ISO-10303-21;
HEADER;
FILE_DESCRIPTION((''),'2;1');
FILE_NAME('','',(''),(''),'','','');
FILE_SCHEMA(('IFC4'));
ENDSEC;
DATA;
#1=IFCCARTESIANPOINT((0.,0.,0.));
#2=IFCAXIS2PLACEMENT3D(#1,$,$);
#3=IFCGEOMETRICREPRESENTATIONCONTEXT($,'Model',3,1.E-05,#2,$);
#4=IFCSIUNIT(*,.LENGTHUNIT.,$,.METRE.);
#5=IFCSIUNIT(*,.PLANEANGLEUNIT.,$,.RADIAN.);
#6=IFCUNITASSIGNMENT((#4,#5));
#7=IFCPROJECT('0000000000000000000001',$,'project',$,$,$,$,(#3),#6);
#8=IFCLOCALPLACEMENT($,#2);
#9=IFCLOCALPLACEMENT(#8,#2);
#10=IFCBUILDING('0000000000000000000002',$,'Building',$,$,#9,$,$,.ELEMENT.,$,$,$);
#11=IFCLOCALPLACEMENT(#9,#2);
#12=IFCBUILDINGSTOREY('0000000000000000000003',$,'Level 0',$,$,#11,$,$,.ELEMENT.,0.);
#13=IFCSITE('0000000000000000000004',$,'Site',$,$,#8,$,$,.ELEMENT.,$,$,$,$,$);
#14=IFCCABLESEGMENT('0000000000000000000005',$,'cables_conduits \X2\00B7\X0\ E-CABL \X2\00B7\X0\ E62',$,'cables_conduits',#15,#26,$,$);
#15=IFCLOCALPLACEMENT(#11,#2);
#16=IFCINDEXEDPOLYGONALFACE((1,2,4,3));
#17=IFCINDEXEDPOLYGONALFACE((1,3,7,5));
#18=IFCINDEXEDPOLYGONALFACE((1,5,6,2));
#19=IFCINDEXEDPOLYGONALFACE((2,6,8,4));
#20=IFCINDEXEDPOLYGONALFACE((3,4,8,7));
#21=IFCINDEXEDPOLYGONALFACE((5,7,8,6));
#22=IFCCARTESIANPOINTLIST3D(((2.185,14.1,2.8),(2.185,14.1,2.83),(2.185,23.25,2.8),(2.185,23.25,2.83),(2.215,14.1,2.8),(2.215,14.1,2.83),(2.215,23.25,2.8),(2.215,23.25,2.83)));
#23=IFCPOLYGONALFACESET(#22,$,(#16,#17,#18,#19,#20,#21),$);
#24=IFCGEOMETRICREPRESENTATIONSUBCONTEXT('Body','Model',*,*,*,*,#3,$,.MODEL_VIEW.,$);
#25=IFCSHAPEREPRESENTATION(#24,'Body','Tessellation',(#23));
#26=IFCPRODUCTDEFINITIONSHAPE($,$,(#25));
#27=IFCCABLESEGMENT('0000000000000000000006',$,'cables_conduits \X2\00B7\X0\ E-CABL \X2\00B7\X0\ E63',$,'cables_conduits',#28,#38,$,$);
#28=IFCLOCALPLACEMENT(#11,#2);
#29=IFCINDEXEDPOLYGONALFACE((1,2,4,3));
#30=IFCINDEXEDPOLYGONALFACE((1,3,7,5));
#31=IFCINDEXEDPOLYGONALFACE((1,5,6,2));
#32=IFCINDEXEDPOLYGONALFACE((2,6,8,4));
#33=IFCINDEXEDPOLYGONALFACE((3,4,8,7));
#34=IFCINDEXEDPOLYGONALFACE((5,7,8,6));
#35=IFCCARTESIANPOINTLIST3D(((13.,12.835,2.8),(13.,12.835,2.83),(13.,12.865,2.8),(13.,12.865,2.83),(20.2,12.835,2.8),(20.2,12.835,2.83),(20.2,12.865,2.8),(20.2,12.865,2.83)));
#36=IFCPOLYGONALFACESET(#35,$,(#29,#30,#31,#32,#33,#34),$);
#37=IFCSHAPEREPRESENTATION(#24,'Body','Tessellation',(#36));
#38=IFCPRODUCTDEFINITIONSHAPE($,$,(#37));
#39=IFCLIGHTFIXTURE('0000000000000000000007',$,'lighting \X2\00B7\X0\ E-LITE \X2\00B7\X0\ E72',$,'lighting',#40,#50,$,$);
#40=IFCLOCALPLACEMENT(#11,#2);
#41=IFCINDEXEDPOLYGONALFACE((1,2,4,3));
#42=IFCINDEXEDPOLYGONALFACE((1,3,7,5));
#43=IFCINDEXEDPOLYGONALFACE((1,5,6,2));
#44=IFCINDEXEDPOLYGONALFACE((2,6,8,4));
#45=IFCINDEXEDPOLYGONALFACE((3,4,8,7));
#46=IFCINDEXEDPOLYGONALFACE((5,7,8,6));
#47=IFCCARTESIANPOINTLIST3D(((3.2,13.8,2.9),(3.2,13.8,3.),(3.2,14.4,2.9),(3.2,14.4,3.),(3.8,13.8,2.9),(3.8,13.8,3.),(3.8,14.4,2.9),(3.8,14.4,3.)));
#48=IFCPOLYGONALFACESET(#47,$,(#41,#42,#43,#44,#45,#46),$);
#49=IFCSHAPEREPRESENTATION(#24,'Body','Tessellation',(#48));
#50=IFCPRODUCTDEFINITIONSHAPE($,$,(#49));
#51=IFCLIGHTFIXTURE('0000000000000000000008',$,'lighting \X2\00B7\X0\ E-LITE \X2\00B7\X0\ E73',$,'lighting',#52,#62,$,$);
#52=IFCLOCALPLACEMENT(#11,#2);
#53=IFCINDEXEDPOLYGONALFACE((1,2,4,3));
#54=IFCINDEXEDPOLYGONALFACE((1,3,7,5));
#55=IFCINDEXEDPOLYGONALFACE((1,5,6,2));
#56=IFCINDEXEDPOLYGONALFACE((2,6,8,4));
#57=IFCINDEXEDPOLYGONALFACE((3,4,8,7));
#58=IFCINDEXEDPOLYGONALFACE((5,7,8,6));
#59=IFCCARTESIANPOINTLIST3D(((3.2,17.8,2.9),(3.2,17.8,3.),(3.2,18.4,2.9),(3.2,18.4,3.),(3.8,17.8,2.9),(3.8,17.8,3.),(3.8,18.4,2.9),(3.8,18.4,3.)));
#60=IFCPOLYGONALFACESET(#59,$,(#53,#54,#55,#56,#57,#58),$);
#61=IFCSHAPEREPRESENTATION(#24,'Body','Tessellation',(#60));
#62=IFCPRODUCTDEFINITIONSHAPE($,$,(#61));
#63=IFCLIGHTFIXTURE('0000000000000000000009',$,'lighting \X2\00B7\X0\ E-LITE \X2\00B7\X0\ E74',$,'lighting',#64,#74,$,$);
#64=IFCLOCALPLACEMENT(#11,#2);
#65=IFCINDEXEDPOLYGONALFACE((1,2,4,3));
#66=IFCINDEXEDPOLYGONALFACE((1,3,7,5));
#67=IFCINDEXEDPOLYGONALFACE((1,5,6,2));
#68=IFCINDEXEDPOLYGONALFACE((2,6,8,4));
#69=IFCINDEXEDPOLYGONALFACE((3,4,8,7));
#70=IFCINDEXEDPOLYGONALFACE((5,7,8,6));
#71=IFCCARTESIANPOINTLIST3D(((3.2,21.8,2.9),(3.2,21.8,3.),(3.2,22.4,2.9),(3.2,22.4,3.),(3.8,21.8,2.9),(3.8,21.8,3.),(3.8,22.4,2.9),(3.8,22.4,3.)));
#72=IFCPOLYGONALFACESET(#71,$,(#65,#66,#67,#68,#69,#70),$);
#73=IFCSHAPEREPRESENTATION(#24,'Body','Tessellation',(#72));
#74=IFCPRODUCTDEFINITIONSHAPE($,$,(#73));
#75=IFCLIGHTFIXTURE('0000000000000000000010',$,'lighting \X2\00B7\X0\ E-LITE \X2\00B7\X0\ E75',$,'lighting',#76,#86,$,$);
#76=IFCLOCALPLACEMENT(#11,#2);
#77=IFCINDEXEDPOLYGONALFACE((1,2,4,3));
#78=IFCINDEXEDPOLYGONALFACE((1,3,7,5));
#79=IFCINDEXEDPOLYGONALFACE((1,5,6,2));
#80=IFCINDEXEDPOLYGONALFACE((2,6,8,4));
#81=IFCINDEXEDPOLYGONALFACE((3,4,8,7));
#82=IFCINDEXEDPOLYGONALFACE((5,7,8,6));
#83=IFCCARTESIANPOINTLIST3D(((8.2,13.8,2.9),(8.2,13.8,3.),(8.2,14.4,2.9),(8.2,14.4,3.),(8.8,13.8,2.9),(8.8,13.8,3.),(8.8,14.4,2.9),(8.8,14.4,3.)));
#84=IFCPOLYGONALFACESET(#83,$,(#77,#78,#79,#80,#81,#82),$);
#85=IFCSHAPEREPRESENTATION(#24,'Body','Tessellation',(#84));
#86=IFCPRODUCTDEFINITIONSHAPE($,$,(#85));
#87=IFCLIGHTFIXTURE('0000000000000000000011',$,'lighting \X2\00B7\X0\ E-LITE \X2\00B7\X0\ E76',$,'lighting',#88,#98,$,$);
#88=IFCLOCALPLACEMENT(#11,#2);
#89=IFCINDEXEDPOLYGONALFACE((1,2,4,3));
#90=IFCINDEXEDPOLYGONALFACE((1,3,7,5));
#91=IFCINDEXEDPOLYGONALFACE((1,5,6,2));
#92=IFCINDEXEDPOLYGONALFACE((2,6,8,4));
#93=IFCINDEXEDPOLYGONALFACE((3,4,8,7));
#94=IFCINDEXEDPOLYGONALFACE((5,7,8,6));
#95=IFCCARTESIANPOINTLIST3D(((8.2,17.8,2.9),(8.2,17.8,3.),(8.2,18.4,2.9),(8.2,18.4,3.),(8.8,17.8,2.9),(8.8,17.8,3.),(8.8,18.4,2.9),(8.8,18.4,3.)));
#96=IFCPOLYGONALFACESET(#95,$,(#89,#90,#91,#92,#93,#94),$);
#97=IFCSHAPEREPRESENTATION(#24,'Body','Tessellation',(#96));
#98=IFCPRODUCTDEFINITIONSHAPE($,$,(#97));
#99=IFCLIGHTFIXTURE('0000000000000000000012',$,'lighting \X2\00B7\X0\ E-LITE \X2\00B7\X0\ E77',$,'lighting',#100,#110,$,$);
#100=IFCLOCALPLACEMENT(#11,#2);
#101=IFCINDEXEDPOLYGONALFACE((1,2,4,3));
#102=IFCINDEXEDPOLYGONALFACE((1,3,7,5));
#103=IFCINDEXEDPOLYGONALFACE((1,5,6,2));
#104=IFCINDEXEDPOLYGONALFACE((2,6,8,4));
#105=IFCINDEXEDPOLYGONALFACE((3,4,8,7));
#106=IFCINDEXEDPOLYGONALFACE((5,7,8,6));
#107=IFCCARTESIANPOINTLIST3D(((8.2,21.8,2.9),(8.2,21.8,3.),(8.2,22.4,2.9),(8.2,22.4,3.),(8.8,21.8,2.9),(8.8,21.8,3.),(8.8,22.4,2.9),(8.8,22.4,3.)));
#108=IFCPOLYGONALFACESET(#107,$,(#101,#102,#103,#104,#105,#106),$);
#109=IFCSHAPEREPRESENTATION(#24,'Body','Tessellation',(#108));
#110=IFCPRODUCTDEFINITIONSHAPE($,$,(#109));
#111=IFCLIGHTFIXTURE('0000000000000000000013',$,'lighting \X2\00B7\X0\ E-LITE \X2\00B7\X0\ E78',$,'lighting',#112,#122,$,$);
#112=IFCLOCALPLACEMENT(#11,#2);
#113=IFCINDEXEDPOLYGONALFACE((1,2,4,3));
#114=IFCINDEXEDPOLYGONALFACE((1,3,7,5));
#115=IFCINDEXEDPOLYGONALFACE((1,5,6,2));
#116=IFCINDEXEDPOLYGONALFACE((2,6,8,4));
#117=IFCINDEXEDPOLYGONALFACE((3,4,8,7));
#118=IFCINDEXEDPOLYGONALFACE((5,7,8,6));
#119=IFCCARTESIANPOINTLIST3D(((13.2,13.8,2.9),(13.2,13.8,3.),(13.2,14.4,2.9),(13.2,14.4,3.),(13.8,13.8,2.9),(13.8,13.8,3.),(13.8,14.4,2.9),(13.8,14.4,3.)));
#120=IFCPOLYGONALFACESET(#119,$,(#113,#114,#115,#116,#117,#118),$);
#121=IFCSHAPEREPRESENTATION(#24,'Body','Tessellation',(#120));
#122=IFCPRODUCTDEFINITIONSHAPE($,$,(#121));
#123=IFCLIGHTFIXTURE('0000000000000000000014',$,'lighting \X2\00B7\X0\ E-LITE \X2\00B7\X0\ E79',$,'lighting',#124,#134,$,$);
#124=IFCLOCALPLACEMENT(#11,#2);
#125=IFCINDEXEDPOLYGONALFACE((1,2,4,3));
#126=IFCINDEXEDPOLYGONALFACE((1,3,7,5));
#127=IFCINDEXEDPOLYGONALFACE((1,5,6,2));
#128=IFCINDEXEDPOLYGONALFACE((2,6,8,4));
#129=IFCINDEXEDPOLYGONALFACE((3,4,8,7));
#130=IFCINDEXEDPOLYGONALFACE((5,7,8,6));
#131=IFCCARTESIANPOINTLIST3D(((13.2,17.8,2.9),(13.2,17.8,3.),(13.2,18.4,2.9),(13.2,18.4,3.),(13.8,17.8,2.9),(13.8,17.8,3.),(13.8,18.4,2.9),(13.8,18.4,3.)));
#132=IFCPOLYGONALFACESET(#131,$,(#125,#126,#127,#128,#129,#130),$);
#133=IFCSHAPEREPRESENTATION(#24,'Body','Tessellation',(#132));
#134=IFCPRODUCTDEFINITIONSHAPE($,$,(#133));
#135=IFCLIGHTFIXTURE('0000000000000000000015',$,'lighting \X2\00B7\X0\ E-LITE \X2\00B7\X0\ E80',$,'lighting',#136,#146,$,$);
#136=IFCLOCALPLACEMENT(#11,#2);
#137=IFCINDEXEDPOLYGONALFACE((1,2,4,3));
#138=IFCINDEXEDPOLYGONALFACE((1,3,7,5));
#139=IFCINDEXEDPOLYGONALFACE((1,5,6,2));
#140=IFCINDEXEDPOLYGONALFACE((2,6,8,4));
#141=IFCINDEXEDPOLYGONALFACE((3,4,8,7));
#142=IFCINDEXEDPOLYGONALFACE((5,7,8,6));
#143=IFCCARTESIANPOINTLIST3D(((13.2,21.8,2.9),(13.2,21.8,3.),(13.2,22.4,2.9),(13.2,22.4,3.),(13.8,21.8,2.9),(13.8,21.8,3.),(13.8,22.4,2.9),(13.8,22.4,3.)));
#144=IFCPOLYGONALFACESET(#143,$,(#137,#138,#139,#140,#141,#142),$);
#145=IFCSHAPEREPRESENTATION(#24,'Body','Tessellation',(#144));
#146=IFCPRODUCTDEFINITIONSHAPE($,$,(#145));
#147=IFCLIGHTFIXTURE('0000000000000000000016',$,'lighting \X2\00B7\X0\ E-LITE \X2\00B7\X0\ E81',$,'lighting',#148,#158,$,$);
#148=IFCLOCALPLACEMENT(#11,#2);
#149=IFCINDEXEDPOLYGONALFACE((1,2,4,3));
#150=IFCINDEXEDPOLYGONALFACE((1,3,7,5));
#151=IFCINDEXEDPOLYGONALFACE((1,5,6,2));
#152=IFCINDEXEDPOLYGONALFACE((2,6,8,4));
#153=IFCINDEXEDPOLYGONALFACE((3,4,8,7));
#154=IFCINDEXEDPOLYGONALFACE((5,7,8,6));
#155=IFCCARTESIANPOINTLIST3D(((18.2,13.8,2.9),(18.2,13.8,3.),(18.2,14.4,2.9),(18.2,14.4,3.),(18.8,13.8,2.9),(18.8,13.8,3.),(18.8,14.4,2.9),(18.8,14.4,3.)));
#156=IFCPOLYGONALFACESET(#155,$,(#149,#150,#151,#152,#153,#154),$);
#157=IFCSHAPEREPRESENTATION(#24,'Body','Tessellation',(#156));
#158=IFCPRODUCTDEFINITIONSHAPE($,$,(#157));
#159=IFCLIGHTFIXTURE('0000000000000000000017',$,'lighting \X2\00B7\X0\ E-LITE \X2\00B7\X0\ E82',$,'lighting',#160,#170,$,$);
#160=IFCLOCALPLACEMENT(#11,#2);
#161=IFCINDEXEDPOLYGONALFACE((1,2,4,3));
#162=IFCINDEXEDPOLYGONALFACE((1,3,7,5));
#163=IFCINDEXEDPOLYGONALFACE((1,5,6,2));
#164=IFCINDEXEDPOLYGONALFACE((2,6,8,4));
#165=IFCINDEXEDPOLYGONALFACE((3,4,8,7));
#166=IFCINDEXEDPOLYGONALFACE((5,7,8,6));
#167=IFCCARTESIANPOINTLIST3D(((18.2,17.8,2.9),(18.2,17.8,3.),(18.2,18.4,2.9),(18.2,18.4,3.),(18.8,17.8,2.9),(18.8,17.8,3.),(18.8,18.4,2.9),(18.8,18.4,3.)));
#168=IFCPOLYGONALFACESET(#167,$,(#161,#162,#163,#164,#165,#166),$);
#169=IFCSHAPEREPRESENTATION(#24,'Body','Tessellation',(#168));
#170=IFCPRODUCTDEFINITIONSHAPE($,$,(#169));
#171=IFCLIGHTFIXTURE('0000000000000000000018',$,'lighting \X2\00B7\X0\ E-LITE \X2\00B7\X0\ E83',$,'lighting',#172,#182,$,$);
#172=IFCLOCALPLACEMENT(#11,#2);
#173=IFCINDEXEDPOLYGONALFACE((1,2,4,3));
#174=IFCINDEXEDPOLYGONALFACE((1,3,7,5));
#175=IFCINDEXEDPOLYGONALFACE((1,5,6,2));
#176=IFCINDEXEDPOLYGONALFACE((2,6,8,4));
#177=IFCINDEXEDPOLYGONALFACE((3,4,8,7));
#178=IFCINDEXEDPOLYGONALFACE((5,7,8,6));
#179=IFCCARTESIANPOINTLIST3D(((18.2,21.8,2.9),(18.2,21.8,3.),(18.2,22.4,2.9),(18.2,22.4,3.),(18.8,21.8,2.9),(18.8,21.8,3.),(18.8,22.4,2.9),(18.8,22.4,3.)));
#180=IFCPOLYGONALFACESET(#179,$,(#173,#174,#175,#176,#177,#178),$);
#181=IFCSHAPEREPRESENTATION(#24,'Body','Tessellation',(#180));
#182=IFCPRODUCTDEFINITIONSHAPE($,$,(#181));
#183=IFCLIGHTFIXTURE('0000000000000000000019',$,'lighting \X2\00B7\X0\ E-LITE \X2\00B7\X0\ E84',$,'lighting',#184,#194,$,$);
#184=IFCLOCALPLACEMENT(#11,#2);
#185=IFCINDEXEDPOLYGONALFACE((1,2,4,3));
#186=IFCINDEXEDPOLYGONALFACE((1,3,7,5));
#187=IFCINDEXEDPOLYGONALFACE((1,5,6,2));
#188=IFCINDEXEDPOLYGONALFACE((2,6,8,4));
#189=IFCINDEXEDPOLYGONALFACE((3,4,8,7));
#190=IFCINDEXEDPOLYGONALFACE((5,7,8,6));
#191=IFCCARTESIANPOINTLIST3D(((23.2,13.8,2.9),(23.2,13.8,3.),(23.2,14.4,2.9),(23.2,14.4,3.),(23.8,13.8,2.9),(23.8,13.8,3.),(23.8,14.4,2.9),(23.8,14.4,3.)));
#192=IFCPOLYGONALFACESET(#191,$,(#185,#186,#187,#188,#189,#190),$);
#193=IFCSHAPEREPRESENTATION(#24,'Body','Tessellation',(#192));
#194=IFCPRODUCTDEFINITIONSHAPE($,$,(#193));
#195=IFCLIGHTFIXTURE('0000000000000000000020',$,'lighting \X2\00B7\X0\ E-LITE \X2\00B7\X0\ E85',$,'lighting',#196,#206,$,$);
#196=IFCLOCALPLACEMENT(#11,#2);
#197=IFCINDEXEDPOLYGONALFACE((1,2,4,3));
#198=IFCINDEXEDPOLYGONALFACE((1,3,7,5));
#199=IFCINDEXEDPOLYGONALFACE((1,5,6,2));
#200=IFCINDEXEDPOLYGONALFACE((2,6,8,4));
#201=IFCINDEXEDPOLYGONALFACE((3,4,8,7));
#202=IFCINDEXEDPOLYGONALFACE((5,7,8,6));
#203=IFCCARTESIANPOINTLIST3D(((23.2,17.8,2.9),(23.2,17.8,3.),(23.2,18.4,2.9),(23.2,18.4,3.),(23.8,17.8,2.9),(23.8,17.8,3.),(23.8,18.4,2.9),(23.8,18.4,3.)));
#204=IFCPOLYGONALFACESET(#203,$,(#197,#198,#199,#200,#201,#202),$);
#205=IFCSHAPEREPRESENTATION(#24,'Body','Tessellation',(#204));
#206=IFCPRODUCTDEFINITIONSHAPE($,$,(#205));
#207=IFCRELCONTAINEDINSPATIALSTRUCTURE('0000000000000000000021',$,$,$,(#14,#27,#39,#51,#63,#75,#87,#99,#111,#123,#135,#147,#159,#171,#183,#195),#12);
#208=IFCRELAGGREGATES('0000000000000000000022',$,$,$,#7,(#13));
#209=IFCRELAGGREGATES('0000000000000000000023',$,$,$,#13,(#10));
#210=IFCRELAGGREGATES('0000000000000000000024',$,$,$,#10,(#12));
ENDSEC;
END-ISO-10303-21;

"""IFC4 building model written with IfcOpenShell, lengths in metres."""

from ifc_helpers import new_model, si_unit, frame, origin, place, context, subcontext, project, spatial, polyline, outline, extrude, element, save


model = new_model("IFC4")

# Units and contexts
model_context = context("Model", 3, precision=1e-05, world=origin())
body_context = subcontext(model_context, "Body", "Model", "MODEL_VIEW")
ifc_project = project(units=[si_unit("LENGTHUNIT", "METRE"), si_unit("PLANEANGLEUNIT", "RADIAN")], contexts=[model_context])

# Site, building, storey
site_placement = place(None, origin())
site = spatial("IfcSite", under=ifc_project, at=site_placement, Name="Site", CompositionType="ELEMENT")
building_placement = place(site_placement, origin())
building = spatial("IfcBuilding", under=site, at=building_placement, Name="Building", CompositionType="ELEMENT")
storey_placement = place(building_placement, origin())
storey = spatial("IfcBuildingStorey", under=building, at=storey_placement, Name="Level 0", CompositionType="ELEMENT", Elevation=0.0)

# Cable segments
cable_segment_1_placement = place(storey_placement, frame((0.0, 0.0, 2.8)))
element("IfcCableSegment", 1, at=cable_segment_1_placement, inside=storey, Name="cables_conduits · E-CABL · E62", ObjectType="cables_conduits", context=body_context, shape_type="SweptSolid", body=[
    extrude(outline(polyline([(2.185, 23.25), (2.185, 14.1), (2.215, 14.1), (2.215, 23.25), (2.185, 23.25)])), origin(), (0.0, 0.0, 1.0), 0.03),
])
cable_segment_2_placement = place(storey_placement, frame((0.0, 0.0, 2.8)))
element("IfcCableSegment", 2, at=cable_segment_2_placement, inside=storey, Name="cables_conduits · E-CABL · E63", ObjectType="cables_conduits", context=body_context, shape_type="SweptSolid", body=[
    extrude(outline(polyline([(20.2, 12.865), (13.0, 12.865), (13.0, 12.835), (20.2, 12.835), (20.2, 12.865)])), origin(), (0.0, 0.0, 1.0), 0.03),
])

# Light fixtures
light_fixture_1_placement = place(storey_placement, frame((0.0, 0.0, 2.9)))
element("IfcLightFixture", 3, at=light_fixture_1_placement, inside=storey, Name="lighting · E-LITE · E72", ObjectType="lighting", context=body_context, shape_type="SweptSolid", body=[
    extrude(outline(polyline([(3.2, 13.8), (3.8, 13.8), (3.8, 14.4), (3.2, 14.4), (3.2, 13.8)])), origin(), (0.0, 0.0, 1.0), 0.1),
])
light_fixture_2_placement = place(storey_placement, frame((0.0, 0.0, 2.9)))
element("IfcLightFixture", 4, at=light_fixture_2_placement, inside=storey, Name="lighting · E-LITE · E73", ObjectType="lighting", context=body_context, shape_type="SweptSolid", body=[
    extrude(outline(polyline([(3.2, 17.8), (3.8, 17.8), (3.8, 18.4), (3.2, 18.4), (3.2, 17.8)])), origin(), (0.0, 0.0, 1.0), 0.1),
])
light_fixture_3_placement = place(storey_placement, frame((0.0, 0.0, 2.9)))
element("IfcLightFixture", 5, at=light_fixture_3_placement, inside=storey, Name="lighting · E-LITE · E74", ObjectType="lighting", context=body_context, shape_type="SweptSolid", body=[
    extrude(outline(polyline([(3.2, 21.8), (3.8, 21.8), (3.8, 22.4), (3.2, 22.4), (3.2, 21.8)])), origin(), (0.0, 0.0, 1.0), 0.1),
])
light_fixture_4_placement = place(storey_placement, frame((0.0, 0.0, 2.9)))
element("IfcLightFixture", 6, at=light_fixture_4_placement, inside=storey, Name="lighting · E-LITE · E75", ObjectType="lighting", context=body_context, shape_type="SweptSolid", body=[
    extrude(outline(polyline([(8.2, 13.8), (8.8, 13.8), (8.8, 14.4), (8.2, 14.4), (8.2, 13.8)])), origin(), (0.0, 0.0, 1.0), 0.1),
])
light_fixture_5_placement = place(storey_placement, frame((0.0, 0.0, 2.9)))
element("IfcLightFixture", 7, at=light_fixture_5_placement, inside=storey, Name="lighting · E-LITE · E76", ObjectType="lighting", context=body_context, shape_type="SweptSolid", body=[
    extrude(outline(polyline([(8.2, 17.8), (8.8, 17.8), (8.8, 18.4), (8.2, 18.4), (8.2, 17.8)])), origin(), (0.0, 0.0, 1.0), 0.1),
])
light_fixture_6_placement = place(storey_placement, frame((0.0, 0.0, 2.9)))
element("IfcLightFixture", 8, at=light_fixture_6_placement, inside=storey, Name="lighting · E-LITE · E77", ObjectType="lighting", context=body_context, shape_type="SweptSolid", body=[
    extrude(outline(polyline([(8.2, 21.8), (8.8, 21.8), (8.8, 22.4), (8.2, 22.4), (8.2, 21.8)])), origin(), (0.0, 0.0, 1.0), 0.1),
])
light_fixture_7_placement = place(storey_placement, frame((0.0, 0.0, 2.9)))
element("IfcLightFixture", 9, at=light_fixture_7_placement, inside=storey, Name="lighting · E-LITE · E78", ObjectType="lighting", context=body_context, shape_type="SweptSolid", body=[
    extrude(outline(polyline([(13.2, 13.8), (13.8, 13.8), (13.8, 14.4), (13.2, 14.4), (13.2, 13.8)])), origin(), (0.0, 0.0, 1.0), 0.1),
])
light_fixture_8_placement = place(storey_placement, frame((0.0, 0.0, 2.9)))
element("IfcLightFixture", 10, at=light_fixture_8_placement, inside=storey, Name="lighting · E-LITE · E79", ObjectType="lighting", context=body_context, shape_type="SweptSolid", body=[
    extrude(outline(polyline([(13.2, 17.8), (13.8, 17.8), (13.8, 18.4), (13.2, 18.4), (13.2, 17.8)])), origin(), (0.0, 0.0, 1.0), 0.1),
])
light_fixture_9_placement = place(storey_placement, frame((0.0, 0.0, 2.9)))
element("IfcLightFixture", 11, at=light_fixture_9_placement, inside=storey, Name="lighting · E-LITE · E80", ObjectType="lighting", context=body_context, shape_type="SweptSolid", body=[
    extrude(outline(polyline([(13.2, 21.8), (13.8, 21.8), (13.8, 22.4), (13.2, 22.4), (13.2, 21.8)])), origin(), (0.0, 0.0, 1.0), 0.1),
])
light_fixture_10_placement = place(storey_placement, frame((0.0, 0.0, 2.9)))
element("IfcLightFixture", 12, at=light_fixture_10_placement, inside=storey, Name="lighting · E-LITE · E81", ObjectType="lighting", context=body_context, shape_type="SweptSolid", body=[
    extrude(outline(polyline([(18.2, 13.8), (18.8, 13.8), (18.8, 14.4), (18.2, 14.4), (18.2, 13.8)])), origin(), (0.0, 0.0, 1.0), 0.1),
])
light_fixture_11_placement = place(storey_placement, frame((0.0, 0.0, 2.9)))
element("IfcLightFixture", 13, at=light_fixture_11_placement, inside=storey, Name="lighting · E-LITE · E82", ObjectType="lighting", context=body_context, shape_type="SweptSolid", body=[
    extrude(outline(polyline([(18.2, 17.8), (18.8, 17.8), (18.8, 18.4), (18.2, 18.4), (18.2, 17.8)])), origin(), (0.0, 0.0, 1.0), 0.1),
])
light_fixture_12_placement = place(storey_placement, frame((0.0, 0.0, 2.9)))
element("IfcLightFixture", 14, at=light_fixture_12_placement, inside=storey, Name="lighting · E-LITE · E83", ObjectType="lighting", context=body_context, shape_type="SweptSolid", body=[
    extrude(outline(polyline([(18.2, 21.8), (18.8, 21.8), (18.8, 22.4), (18.2, 22.4), (18.2, 21.8)])), origin(), (0.0, 0.0, 1.0), 0.1),
])
light_fixture_13_placement = place(storey_placement, frame((0.0, 0.0, 2.9)))
element("IfcLightFixture", 15, at=light_fixture_13_placement, inside=storey, Name="lighting · E-LITE · E84", ObjectType="lighting", context=body_context, shape_type="SweptSolid", body=[
    extrude(outline(polyline([(23.2, 13.8), (23.8, 13.8), (23.8, 14.4), (23.2, 14.4), (23.2, 13.8)])), origin(), (0.0, 0.0, 1.0), 0.1),
])
light_fixture_14_placement = place(storey_placement, frame((0.0, 0.0, 2.9)))
element("IfcLightFixture", 16, at=light_fixture_14_placement, inside=storey, Name="lighting · E-LITE · E85", ObjectType="lighting", context=body_context, shape_type="SweptSolid", body=[
    extrude(outline(polyline([(23.2, 17.8), (23.8, 17.8), (23.8, 18.4), (23.2, 18.4), (23.2, 17.8)])), origin(), (0.0, 0.0, 1.0), 0.1),
])

save(model, "model.ifc")
